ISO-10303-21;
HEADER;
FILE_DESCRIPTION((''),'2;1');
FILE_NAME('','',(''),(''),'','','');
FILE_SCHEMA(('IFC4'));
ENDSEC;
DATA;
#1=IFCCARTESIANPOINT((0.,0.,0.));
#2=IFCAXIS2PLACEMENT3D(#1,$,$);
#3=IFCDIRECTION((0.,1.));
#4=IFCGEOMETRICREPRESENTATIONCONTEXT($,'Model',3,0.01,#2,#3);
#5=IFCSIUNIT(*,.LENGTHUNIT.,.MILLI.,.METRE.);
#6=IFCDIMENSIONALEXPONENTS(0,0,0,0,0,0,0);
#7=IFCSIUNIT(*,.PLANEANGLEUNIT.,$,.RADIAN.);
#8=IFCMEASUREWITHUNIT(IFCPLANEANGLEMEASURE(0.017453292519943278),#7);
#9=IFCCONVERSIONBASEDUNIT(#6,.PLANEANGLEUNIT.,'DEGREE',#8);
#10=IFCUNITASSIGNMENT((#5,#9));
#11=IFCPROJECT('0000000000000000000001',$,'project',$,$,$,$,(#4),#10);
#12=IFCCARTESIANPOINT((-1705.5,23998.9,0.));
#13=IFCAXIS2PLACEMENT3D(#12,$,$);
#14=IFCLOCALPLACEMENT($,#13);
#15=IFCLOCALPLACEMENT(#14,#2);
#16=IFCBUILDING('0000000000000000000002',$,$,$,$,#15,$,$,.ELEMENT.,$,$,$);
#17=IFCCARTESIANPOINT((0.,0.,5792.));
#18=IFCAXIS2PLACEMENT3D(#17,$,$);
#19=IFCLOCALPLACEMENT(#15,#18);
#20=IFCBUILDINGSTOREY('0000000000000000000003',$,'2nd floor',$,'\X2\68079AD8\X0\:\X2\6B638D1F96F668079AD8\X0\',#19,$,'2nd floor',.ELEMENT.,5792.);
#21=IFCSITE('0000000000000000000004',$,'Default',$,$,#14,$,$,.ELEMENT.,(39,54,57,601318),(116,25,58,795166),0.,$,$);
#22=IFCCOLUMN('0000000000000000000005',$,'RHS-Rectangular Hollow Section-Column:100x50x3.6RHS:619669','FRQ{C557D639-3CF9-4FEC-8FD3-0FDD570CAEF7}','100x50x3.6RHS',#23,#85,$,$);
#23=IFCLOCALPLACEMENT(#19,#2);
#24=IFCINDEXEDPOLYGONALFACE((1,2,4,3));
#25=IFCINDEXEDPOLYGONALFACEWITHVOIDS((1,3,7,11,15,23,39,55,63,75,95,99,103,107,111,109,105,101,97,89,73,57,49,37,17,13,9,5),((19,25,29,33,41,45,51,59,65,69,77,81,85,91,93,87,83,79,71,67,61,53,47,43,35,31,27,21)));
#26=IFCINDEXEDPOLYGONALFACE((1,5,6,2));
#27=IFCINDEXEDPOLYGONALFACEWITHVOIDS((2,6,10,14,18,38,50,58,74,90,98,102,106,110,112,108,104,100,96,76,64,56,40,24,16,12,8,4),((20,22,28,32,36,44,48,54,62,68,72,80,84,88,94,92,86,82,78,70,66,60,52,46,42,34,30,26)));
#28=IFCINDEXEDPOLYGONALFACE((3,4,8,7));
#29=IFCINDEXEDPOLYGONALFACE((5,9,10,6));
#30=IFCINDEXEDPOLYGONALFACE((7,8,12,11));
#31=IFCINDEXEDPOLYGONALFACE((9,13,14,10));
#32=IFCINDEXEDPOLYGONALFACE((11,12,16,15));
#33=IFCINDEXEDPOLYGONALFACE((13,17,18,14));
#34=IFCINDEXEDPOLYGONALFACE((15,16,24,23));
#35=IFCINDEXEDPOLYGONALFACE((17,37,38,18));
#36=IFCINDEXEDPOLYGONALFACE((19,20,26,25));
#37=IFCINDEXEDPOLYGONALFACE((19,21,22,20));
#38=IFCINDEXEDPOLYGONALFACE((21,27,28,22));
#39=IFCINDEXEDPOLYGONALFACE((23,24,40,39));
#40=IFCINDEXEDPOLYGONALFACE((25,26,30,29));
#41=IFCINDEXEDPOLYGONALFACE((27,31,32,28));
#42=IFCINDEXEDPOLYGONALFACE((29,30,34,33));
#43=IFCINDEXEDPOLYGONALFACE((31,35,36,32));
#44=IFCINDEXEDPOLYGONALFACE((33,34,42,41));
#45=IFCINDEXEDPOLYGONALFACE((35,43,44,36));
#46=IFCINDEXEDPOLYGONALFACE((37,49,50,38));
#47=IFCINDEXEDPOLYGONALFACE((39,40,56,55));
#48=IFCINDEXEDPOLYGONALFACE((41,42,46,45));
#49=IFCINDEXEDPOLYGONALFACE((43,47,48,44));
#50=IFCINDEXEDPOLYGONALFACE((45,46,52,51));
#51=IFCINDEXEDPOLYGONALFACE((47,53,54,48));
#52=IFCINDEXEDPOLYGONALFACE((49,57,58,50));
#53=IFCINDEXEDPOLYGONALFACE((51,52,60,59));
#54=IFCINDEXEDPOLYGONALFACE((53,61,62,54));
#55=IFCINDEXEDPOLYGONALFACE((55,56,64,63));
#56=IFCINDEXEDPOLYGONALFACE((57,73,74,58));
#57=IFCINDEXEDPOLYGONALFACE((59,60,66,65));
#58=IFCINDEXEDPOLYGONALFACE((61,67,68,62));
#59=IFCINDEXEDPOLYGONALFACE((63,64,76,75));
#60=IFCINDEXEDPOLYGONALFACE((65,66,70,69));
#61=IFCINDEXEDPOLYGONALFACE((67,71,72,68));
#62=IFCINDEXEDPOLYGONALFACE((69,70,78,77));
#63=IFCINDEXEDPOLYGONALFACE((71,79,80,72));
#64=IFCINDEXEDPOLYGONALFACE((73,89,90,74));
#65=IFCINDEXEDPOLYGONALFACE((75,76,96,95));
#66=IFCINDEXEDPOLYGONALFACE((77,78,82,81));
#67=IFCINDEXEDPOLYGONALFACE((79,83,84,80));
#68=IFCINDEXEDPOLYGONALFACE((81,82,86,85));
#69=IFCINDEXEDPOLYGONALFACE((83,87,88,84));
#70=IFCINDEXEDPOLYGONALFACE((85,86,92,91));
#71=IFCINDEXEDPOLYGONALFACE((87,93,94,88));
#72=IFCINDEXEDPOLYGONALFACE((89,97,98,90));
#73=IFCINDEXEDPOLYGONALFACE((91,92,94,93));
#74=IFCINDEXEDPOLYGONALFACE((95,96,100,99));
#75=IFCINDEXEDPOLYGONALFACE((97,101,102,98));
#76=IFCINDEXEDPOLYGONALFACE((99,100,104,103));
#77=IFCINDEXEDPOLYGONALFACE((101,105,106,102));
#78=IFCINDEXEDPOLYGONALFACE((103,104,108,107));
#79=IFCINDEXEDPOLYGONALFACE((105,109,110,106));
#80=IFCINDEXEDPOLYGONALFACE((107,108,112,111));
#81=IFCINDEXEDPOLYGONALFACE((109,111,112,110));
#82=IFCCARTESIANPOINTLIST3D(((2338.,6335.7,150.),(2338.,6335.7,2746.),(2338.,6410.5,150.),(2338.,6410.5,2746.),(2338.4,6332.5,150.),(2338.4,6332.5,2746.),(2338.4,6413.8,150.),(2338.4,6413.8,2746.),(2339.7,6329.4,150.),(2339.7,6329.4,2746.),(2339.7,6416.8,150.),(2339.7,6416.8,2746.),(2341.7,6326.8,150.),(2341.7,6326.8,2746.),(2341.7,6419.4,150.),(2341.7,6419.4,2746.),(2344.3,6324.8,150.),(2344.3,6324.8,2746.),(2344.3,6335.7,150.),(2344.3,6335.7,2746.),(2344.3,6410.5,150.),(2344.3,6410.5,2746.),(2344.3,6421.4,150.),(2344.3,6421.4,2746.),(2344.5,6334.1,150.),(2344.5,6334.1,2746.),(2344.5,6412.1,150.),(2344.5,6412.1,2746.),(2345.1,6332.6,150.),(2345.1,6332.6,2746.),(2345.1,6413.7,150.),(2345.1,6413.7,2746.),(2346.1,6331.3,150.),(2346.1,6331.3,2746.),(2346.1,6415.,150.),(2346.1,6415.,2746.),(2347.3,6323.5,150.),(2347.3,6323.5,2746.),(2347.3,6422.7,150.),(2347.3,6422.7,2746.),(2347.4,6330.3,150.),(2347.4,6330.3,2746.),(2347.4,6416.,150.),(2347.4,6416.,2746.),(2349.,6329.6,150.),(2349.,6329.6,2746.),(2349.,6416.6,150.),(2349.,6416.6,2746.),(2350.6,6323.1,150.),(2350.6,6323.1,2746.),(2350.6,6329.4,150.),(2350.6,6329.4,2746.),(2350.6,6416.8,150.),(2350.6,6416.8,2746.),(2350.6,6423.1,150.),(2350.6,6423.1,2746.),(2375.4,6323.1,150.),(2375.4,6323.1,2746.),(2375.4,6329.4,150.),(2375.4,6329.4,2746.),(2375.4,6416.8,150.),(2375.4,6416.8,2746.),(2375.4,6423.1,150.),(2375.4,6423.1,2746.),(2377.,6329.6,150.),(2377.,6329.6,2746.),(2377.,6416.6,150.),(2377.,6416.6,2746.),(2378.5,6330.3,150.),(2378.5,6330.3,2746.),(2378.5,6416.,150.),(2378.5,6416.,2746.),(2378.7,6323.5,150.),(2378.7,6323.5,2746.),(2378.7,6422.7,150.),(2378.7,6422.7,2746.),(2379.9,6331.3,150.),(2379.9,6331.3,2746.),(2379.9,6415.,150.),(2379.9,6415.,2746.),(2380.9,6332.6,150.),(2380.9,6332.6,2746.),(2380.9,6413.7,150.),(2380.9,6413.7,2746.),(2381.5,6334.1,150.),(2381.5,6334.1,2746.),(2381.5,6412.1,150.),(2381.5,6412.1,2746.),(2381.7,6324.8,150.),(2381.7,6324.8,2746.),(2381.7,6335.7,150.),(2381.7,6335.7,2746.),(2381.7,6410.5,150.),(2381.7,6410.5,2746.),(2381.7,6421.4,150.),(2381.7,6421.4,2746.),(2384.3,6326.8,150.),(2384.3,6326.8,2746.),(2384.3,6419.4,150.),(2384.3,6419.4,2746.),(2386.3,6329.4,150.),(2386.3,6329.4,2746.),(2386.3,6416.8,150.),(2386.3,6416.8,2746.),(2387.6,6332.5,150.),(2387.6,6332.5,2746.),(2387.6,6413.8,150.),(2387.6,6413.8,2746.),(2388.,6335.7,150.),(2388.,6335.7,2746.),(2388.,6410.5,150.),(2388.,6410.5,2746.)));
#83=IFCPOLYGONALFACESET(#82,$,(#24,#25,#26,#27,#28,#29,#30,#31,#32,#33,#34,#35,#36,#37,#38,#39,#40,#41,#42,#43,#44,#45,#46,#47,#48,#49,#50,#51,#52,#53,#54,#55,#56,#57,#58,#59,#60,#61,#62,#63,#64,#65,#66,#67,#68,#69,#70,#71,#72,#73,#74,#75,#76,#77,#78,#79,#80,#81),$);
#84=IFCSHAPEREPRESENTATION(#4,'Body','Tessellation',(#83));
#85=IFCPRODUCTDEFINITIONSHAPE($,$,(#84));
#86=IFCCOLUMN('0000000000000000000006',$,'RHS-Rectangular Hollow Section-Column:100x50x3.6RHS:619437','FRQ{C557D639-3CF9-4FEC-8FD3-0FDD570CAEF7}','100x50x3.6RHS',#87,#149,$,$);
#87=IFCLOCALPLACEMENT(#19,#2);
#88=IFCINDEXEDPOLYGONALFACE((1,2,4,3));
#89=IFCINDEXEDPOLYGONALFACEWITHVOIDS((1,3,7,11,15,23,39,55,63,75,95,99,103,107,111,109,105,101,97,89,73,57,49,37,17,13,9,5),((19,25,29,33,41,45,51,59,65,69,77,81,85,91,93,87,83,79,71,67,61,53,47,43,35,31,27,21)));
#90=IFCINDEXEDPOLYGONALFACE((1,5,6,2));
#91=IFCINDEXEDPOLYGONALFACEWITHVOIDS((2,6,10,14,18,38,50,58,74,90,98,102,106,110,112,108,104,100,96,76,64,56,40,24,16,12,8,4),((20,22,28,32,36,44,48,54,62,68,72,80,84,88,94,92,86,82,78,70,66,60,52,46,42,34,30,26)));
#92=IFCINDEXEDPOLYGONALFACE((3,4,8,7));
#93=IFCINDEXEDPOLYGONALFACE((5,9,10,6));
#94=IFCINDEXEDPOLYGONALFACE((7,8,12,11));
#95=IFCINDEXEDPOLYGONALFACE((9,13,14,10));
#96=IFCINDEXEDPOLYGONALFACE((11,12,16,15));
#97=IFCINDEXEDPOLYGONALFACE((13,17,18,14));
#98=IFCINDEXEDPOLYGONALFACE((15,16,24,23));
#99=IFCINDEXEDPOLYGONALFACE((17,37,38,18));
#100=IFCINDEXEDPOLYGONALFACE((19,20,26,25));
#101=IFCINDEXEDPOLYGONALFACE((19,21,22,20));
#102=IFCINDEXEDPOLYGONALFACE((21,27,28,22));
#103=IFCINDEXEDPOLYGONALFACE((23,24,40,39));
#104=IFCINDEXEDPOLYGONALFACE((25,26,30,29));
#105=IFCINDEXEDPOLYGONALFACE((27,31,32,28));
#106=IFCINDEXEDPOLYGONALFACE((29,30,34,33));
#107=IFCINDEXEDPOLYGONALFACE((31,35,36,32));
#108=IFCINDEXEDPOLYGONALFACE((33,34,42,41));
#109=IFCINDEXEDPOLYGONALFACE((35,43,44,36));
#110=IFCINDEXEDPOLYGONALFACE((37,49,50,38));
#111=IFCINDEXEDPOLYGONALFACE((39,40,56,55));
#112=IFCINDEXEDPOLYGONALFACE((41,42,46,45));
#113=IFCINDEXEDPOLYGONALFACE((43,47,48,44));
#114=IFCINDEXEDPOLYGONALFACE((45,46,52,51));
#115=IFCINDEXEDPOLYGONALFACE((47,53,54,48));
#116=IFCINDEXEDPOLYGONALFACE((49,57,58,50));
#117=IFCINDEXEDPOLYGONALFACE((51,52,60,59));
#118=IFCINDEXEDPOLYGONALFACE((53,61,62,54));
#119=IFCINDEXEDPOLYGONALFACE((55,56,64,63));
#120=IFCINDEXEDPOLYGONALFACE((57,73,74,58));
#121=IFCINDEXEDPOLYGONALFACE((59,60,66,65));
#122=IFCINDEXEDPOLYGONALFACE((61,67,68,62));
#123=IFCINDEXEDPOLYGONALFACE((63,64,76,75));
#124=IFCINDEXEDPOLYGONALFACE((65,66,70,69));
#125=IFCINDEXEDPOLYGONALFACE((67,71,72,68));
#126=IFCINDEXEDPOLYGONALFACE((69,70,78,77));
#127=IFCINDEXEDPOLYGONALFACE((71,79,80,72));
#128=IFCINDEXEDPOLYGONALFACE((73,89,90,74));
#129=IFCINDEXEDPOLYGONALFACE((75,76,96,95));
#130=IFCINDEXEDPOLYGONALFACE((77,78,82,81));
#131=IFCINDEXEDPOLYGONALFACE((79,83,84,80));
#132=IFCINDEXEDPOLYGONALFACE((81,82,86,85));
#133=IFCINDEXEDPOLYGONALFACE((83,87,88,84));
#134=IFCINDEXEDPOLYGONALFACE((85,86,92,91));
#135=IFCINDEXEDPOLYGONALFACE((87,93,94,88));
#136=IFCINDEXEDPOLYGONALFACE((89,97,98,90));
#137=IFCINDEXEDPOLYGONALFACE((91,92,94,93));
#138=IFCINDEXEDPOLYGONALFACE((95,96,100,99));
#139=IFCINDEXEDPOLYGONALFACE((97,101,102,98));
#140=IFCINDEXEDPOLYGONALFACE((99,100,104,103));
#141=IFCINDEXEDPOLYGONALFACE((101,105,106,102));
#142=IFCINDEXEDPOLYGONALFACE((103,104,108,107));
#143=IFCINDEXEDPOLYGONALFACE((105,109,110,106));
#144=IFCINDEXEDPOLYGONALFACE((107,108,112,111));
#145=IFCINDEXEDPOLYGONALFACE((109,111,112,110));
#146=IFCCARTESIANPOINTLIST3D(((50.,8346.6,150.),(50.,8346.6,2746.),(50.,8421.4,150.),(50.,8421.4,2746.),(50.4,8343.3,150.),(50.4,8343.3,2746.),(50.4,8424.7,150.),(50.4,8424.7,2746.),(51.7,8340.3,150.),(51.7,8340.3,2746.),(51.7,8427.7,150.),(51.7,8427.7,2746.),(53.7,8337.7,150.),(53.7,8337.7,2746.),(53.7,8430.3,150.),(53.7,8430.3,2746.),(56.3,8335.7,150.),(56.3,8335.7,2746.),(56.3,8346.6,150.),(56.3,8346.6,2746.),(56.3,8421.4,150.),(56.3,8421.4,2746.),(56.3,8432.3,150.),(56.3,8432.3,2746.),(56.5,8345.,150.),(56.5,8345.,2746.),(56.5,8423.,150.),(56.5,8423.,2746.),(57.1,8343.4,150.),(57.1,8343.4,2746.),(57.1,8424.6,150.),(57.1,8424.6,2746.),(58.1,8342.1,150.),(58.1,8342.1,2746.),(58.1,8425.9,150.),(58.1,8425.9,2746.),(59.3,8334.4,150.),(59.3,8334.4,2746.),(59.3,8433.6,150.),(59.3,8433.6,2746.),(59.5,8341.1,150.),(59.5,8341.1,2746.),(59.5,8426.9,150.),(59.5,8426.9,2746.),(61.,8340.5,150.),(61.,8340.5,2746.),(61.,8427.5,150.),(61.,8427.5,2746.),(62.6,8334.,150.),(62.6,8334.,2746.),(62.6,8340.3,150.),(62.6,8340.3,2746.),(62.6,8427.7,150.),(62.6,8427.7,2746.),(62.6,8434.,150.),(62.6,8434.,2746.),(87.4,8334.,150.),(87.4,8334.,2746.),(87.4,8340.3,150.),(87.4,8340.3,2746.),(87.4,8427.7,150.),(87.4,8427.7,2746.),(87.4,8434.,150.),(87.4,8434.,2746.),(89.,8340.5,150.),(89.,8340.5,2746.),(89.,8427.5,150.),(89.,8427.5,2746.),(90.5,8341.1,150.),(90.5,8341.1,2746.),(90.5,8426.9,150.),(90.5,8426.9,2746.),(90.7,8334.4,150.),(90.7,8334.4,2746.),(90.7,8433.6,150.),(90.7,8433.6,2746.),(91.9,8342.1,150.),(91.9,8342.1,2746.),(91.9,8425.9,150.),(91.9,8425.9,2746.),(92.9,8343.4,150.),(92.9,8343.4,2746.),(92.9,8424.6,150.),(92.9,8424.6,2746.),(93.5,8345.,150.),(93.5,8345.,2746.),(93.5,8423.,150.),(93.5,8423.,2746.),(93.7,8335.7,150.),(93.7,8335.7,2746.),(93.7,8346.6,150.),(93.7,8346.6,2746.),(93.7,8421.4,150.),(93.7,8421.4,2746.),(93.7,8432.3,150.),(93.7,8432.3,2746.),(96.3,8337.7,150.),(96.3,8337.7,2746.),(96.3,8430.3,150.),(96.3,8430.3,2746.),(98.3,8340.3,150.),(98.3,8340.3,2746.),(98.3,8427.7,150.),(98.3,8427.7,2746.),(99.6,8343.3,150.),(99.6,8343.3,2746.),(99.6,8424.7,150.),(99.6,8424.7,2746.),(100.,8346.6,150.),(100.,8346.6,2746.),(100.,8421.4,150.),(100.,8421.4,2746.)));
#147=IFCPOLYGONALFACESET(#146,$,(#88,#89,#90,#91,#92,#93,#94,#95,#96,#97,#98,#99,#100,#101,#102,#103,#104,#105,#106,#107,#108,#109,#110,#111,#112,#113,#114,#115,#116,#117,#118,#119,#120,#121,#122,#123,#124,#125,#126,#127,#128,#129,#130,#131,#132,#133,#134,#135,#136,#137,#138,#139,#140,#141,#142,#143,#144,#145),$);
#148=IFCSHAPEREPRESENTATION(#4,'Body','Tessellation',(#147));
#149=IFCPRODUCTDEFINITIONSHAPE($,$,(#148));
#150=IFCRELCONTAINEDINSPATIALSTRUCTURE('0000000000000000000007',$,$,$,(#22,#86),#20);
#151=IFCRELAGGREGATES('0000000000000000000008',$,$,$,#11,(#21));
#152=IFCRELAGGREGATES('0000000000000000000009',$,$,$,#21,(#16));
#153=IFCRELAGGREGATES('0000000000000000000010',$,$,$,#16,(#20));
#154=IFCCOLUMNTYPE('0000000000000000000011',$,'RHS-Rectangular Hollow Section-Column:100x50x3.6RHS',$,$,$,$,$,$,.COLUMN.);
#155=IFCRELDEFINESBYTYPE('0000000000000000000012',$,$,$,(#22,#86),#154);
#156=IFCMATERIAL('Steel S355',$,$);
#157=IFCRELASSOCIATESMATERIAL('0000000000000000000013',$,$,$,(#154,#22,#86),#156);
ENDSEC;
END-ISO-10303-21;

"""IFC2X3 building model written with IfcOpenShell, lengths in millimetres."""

from ifc_helpers import new_model, entity, si_unit, converted_unit, point, direction, frame, frame_2d, origin, origin_2d, place, context, project, spatial, circle_curve, line_curve, trimmed, segment, composite_curve, hollow_rectangle, outline, extrude, clip, halfspace, material, type_object, element, save


model = new_model("IFC2X3")

# Units and contexts
model_context = context("Model", 3, precision=0.01, world=origin(), true_north=direction((0.0, 1.0)))
ifc_project = project(units=[si_unit("LENGTHUNIT", "METRE", prefix="MILLI"), converted_unit("PLANEANGLEUNIT", "DEGREE", entity("IfcPlaneAngleMeasure", 0.017453292519943278), si_unit("PLANEANGLEUNIT", "RADIAN"), dimensions=[0, 0, 0, 0, 0, 0, 0])], contexts=[model_context])

# Site, building, storey
site_placement = place(None, frame((-1705.5, 23998.9, 0.0)))
site = spatial("IfcSite", under=ifc_project, at=site_placement, Name="Default", CompositionType="ELEMENT", RefLatitude=(39, 54, 57, 601318), RefLongitude=(116, 25, 58, 795166), RefElevation=0.0)
building_placement = place(site_placement, origin())
building = spatial("IfcBuilding", under=site, at=building_placement, CompositionType="ELEMENT")
storey_placement = place(building_placement, frame((0.0, 0.0, 5792.0)))
storey = spatial("IfcBuildingStorey", under=building, at=storey_placement, Name="2nd floor", ObjectType="标高:正负零标高", LongName="2nd floor", CompositionType="ELEMENT", Elevation=5792.0)

# Column
ifc_material_1 = material(Name="Steel S355")
column_type = type_object("IfcColumnType", Name="RHS-Rectangular Hollow Section-Column:100x50x3.6RHS", PredefinedType="COLUMN", material=ifc_material_1)
column_1_placement = place(storey_placement, frame((2363.0, 6373.1, 2746.0), z_axis=(0.0, 0.0, 1.0), x_axis=(-1.0, 0.0, 0.0)))
element("IfcColumn", 1, at=column_1_placement, inside=storey, type_object=column_type, material=ifc_material_1, Name="RHS-Rectangular Hollow Section-Column:100x50x3.6RHS:619669", Description="FRQ{C557D639-3CF9-4FEC-8FD3-0FDD570CAEF7}", ObjectType="100x50x3.6RHS", context=model_context, shape_type="Clipping", body=[
    clip(extrude(hollow_rectangle(XDim=50.0, YDim=100.0, WallThickness=6.3, InnerFilletRadius=6.3, OuterFilletRadius=12.6, at=origin_2d()), origin(), (0.0, 0.0, -1.0), 2651.9), halfspace(frame((2363.0, 6373.1, -2596.0), z_axis=(0.0, 0.0, 1.0), x_axis=(-1.0, 0.0, 0.0)), True)),
])

# Column, opening
column_2_placement = place(storey_placement, frame((75.0, 8384.0, 2876.9)))
column_2 = element("IfcColumn", 2, at=column_2_placement, inside=storey, type_object=column_type, material=ifc_material_1, Name="RHS-Rectangular Hollow Section-Column:100x50x3.6RHS:619437", Description="FRQ{C557D639-3CF9-4FEC-8FD3-0FDD570CAEF7}", ObjectType="100x50x3.6RHS", context=model_context, shape_type="Clipping", body=[
    clip(clip(extrude(hollow_rectangle(XDim=50.0, YDim=100.0, WallThickness=6.3, InnerFilletRadius=6.3, OuterFilletRadius=12.6, at=origin_2d()), origin(), (0.0, 0.0, -1.0), 2782.8), halfspace(frame((-75.0, -8384.0, -55.9), z_axis=(0.0, 0.0, -1.0), x_axis=(-1.0, 0.0, 0.0)), True)), halfspace(frame((-75.0, -8384.0, -2726.9), z_axis=(0.0, 0.0, 1.0), x_axis=(1.0, 0.0, 0.0)), True)),
])
opening_1_placement = place(column_2_placement, frame((0.0, -150.1, -130.9), z_axis=(0.0, 1.0, 0.0), x_axis=(-1.0, 0.0, 0.0)))
element("IfcOpeningElement", 3, at=opening_1_placement, cuts=column_2, ObjectType="Opening", context=model_context, shape_type="SweptSolid", body=[
    extrude(outline(composite_curve([segment(trimmed(circle_curve(frame_2d((43.0, 32.0), x_axis=(1.0, 0.0)), 32.0), [point((43.0, 0.0))], [point((75.0, 32.0))], True, "CARTESIAN"), True, "CONTINUOUS"), segment(trimmed(line_curve((75.0, 32.0), (0.0, 1.0), 86.0), [point((75.0, 32.0))], [point((75.0, 118.0))], True, "CARTESIAN"), True, "CONTINUOUS"), segment(trimmed(circle_curve(frame_2d((43.0, 118.0), x_axis=(1.0, 0.0)), 32.0), [point((75.0, 118.0))], [point((43.0, 150.0))], True, "CARTESIAN"), True, "CONTINUOUS"), segment(trimmed(line_curve((43.0, 150.0), (-1.0, 0.0), 86.0), [point((43.0, 150.0))], [point((-43.0, 150.0))], True, "CARTESIAN"), True, "CONTINUOUS"), segment(trimmed(circle_curve(frame_2d((-43.0, 118.0), x_axis=(1.0, 0.0)), 32.0), [point((-43.0, 150.0))], [point((-75.0, 118.0))], True, "CARTESIAN"), True, "CONTINUOUS"), segment(trimmed(line_curve((-75.0, 118.0), (0.0, -1.0), 86.0), [point((-75.0, 118.0))], [point((-75.0, 32.0))], True, "CARTESIAN"), True, "CONTINUOUS"), segment(trimmed(circle_curve(frame_2d((-43.0, 32.0), x_axis=(1.0, 0.0)), 32.0), [point((-75.0, 32.0))], [point((-43.0, 0.0))], True, "CARTESIAN"), True, "CONTINUOUS"), segment(trimmed(line_curve((-43.0, 0.0), (1.0, 0.0), 86.0), [point((-43.0, 0.0))], [point((43.0, 0.0))], True, "CARTESIAN"), True, "CONTINUOUS")], self_intersect="UNKNOWN")), origin(), (0.0, 0.0, 1.0), 300.2),
])

save(model, "model.ifc")
